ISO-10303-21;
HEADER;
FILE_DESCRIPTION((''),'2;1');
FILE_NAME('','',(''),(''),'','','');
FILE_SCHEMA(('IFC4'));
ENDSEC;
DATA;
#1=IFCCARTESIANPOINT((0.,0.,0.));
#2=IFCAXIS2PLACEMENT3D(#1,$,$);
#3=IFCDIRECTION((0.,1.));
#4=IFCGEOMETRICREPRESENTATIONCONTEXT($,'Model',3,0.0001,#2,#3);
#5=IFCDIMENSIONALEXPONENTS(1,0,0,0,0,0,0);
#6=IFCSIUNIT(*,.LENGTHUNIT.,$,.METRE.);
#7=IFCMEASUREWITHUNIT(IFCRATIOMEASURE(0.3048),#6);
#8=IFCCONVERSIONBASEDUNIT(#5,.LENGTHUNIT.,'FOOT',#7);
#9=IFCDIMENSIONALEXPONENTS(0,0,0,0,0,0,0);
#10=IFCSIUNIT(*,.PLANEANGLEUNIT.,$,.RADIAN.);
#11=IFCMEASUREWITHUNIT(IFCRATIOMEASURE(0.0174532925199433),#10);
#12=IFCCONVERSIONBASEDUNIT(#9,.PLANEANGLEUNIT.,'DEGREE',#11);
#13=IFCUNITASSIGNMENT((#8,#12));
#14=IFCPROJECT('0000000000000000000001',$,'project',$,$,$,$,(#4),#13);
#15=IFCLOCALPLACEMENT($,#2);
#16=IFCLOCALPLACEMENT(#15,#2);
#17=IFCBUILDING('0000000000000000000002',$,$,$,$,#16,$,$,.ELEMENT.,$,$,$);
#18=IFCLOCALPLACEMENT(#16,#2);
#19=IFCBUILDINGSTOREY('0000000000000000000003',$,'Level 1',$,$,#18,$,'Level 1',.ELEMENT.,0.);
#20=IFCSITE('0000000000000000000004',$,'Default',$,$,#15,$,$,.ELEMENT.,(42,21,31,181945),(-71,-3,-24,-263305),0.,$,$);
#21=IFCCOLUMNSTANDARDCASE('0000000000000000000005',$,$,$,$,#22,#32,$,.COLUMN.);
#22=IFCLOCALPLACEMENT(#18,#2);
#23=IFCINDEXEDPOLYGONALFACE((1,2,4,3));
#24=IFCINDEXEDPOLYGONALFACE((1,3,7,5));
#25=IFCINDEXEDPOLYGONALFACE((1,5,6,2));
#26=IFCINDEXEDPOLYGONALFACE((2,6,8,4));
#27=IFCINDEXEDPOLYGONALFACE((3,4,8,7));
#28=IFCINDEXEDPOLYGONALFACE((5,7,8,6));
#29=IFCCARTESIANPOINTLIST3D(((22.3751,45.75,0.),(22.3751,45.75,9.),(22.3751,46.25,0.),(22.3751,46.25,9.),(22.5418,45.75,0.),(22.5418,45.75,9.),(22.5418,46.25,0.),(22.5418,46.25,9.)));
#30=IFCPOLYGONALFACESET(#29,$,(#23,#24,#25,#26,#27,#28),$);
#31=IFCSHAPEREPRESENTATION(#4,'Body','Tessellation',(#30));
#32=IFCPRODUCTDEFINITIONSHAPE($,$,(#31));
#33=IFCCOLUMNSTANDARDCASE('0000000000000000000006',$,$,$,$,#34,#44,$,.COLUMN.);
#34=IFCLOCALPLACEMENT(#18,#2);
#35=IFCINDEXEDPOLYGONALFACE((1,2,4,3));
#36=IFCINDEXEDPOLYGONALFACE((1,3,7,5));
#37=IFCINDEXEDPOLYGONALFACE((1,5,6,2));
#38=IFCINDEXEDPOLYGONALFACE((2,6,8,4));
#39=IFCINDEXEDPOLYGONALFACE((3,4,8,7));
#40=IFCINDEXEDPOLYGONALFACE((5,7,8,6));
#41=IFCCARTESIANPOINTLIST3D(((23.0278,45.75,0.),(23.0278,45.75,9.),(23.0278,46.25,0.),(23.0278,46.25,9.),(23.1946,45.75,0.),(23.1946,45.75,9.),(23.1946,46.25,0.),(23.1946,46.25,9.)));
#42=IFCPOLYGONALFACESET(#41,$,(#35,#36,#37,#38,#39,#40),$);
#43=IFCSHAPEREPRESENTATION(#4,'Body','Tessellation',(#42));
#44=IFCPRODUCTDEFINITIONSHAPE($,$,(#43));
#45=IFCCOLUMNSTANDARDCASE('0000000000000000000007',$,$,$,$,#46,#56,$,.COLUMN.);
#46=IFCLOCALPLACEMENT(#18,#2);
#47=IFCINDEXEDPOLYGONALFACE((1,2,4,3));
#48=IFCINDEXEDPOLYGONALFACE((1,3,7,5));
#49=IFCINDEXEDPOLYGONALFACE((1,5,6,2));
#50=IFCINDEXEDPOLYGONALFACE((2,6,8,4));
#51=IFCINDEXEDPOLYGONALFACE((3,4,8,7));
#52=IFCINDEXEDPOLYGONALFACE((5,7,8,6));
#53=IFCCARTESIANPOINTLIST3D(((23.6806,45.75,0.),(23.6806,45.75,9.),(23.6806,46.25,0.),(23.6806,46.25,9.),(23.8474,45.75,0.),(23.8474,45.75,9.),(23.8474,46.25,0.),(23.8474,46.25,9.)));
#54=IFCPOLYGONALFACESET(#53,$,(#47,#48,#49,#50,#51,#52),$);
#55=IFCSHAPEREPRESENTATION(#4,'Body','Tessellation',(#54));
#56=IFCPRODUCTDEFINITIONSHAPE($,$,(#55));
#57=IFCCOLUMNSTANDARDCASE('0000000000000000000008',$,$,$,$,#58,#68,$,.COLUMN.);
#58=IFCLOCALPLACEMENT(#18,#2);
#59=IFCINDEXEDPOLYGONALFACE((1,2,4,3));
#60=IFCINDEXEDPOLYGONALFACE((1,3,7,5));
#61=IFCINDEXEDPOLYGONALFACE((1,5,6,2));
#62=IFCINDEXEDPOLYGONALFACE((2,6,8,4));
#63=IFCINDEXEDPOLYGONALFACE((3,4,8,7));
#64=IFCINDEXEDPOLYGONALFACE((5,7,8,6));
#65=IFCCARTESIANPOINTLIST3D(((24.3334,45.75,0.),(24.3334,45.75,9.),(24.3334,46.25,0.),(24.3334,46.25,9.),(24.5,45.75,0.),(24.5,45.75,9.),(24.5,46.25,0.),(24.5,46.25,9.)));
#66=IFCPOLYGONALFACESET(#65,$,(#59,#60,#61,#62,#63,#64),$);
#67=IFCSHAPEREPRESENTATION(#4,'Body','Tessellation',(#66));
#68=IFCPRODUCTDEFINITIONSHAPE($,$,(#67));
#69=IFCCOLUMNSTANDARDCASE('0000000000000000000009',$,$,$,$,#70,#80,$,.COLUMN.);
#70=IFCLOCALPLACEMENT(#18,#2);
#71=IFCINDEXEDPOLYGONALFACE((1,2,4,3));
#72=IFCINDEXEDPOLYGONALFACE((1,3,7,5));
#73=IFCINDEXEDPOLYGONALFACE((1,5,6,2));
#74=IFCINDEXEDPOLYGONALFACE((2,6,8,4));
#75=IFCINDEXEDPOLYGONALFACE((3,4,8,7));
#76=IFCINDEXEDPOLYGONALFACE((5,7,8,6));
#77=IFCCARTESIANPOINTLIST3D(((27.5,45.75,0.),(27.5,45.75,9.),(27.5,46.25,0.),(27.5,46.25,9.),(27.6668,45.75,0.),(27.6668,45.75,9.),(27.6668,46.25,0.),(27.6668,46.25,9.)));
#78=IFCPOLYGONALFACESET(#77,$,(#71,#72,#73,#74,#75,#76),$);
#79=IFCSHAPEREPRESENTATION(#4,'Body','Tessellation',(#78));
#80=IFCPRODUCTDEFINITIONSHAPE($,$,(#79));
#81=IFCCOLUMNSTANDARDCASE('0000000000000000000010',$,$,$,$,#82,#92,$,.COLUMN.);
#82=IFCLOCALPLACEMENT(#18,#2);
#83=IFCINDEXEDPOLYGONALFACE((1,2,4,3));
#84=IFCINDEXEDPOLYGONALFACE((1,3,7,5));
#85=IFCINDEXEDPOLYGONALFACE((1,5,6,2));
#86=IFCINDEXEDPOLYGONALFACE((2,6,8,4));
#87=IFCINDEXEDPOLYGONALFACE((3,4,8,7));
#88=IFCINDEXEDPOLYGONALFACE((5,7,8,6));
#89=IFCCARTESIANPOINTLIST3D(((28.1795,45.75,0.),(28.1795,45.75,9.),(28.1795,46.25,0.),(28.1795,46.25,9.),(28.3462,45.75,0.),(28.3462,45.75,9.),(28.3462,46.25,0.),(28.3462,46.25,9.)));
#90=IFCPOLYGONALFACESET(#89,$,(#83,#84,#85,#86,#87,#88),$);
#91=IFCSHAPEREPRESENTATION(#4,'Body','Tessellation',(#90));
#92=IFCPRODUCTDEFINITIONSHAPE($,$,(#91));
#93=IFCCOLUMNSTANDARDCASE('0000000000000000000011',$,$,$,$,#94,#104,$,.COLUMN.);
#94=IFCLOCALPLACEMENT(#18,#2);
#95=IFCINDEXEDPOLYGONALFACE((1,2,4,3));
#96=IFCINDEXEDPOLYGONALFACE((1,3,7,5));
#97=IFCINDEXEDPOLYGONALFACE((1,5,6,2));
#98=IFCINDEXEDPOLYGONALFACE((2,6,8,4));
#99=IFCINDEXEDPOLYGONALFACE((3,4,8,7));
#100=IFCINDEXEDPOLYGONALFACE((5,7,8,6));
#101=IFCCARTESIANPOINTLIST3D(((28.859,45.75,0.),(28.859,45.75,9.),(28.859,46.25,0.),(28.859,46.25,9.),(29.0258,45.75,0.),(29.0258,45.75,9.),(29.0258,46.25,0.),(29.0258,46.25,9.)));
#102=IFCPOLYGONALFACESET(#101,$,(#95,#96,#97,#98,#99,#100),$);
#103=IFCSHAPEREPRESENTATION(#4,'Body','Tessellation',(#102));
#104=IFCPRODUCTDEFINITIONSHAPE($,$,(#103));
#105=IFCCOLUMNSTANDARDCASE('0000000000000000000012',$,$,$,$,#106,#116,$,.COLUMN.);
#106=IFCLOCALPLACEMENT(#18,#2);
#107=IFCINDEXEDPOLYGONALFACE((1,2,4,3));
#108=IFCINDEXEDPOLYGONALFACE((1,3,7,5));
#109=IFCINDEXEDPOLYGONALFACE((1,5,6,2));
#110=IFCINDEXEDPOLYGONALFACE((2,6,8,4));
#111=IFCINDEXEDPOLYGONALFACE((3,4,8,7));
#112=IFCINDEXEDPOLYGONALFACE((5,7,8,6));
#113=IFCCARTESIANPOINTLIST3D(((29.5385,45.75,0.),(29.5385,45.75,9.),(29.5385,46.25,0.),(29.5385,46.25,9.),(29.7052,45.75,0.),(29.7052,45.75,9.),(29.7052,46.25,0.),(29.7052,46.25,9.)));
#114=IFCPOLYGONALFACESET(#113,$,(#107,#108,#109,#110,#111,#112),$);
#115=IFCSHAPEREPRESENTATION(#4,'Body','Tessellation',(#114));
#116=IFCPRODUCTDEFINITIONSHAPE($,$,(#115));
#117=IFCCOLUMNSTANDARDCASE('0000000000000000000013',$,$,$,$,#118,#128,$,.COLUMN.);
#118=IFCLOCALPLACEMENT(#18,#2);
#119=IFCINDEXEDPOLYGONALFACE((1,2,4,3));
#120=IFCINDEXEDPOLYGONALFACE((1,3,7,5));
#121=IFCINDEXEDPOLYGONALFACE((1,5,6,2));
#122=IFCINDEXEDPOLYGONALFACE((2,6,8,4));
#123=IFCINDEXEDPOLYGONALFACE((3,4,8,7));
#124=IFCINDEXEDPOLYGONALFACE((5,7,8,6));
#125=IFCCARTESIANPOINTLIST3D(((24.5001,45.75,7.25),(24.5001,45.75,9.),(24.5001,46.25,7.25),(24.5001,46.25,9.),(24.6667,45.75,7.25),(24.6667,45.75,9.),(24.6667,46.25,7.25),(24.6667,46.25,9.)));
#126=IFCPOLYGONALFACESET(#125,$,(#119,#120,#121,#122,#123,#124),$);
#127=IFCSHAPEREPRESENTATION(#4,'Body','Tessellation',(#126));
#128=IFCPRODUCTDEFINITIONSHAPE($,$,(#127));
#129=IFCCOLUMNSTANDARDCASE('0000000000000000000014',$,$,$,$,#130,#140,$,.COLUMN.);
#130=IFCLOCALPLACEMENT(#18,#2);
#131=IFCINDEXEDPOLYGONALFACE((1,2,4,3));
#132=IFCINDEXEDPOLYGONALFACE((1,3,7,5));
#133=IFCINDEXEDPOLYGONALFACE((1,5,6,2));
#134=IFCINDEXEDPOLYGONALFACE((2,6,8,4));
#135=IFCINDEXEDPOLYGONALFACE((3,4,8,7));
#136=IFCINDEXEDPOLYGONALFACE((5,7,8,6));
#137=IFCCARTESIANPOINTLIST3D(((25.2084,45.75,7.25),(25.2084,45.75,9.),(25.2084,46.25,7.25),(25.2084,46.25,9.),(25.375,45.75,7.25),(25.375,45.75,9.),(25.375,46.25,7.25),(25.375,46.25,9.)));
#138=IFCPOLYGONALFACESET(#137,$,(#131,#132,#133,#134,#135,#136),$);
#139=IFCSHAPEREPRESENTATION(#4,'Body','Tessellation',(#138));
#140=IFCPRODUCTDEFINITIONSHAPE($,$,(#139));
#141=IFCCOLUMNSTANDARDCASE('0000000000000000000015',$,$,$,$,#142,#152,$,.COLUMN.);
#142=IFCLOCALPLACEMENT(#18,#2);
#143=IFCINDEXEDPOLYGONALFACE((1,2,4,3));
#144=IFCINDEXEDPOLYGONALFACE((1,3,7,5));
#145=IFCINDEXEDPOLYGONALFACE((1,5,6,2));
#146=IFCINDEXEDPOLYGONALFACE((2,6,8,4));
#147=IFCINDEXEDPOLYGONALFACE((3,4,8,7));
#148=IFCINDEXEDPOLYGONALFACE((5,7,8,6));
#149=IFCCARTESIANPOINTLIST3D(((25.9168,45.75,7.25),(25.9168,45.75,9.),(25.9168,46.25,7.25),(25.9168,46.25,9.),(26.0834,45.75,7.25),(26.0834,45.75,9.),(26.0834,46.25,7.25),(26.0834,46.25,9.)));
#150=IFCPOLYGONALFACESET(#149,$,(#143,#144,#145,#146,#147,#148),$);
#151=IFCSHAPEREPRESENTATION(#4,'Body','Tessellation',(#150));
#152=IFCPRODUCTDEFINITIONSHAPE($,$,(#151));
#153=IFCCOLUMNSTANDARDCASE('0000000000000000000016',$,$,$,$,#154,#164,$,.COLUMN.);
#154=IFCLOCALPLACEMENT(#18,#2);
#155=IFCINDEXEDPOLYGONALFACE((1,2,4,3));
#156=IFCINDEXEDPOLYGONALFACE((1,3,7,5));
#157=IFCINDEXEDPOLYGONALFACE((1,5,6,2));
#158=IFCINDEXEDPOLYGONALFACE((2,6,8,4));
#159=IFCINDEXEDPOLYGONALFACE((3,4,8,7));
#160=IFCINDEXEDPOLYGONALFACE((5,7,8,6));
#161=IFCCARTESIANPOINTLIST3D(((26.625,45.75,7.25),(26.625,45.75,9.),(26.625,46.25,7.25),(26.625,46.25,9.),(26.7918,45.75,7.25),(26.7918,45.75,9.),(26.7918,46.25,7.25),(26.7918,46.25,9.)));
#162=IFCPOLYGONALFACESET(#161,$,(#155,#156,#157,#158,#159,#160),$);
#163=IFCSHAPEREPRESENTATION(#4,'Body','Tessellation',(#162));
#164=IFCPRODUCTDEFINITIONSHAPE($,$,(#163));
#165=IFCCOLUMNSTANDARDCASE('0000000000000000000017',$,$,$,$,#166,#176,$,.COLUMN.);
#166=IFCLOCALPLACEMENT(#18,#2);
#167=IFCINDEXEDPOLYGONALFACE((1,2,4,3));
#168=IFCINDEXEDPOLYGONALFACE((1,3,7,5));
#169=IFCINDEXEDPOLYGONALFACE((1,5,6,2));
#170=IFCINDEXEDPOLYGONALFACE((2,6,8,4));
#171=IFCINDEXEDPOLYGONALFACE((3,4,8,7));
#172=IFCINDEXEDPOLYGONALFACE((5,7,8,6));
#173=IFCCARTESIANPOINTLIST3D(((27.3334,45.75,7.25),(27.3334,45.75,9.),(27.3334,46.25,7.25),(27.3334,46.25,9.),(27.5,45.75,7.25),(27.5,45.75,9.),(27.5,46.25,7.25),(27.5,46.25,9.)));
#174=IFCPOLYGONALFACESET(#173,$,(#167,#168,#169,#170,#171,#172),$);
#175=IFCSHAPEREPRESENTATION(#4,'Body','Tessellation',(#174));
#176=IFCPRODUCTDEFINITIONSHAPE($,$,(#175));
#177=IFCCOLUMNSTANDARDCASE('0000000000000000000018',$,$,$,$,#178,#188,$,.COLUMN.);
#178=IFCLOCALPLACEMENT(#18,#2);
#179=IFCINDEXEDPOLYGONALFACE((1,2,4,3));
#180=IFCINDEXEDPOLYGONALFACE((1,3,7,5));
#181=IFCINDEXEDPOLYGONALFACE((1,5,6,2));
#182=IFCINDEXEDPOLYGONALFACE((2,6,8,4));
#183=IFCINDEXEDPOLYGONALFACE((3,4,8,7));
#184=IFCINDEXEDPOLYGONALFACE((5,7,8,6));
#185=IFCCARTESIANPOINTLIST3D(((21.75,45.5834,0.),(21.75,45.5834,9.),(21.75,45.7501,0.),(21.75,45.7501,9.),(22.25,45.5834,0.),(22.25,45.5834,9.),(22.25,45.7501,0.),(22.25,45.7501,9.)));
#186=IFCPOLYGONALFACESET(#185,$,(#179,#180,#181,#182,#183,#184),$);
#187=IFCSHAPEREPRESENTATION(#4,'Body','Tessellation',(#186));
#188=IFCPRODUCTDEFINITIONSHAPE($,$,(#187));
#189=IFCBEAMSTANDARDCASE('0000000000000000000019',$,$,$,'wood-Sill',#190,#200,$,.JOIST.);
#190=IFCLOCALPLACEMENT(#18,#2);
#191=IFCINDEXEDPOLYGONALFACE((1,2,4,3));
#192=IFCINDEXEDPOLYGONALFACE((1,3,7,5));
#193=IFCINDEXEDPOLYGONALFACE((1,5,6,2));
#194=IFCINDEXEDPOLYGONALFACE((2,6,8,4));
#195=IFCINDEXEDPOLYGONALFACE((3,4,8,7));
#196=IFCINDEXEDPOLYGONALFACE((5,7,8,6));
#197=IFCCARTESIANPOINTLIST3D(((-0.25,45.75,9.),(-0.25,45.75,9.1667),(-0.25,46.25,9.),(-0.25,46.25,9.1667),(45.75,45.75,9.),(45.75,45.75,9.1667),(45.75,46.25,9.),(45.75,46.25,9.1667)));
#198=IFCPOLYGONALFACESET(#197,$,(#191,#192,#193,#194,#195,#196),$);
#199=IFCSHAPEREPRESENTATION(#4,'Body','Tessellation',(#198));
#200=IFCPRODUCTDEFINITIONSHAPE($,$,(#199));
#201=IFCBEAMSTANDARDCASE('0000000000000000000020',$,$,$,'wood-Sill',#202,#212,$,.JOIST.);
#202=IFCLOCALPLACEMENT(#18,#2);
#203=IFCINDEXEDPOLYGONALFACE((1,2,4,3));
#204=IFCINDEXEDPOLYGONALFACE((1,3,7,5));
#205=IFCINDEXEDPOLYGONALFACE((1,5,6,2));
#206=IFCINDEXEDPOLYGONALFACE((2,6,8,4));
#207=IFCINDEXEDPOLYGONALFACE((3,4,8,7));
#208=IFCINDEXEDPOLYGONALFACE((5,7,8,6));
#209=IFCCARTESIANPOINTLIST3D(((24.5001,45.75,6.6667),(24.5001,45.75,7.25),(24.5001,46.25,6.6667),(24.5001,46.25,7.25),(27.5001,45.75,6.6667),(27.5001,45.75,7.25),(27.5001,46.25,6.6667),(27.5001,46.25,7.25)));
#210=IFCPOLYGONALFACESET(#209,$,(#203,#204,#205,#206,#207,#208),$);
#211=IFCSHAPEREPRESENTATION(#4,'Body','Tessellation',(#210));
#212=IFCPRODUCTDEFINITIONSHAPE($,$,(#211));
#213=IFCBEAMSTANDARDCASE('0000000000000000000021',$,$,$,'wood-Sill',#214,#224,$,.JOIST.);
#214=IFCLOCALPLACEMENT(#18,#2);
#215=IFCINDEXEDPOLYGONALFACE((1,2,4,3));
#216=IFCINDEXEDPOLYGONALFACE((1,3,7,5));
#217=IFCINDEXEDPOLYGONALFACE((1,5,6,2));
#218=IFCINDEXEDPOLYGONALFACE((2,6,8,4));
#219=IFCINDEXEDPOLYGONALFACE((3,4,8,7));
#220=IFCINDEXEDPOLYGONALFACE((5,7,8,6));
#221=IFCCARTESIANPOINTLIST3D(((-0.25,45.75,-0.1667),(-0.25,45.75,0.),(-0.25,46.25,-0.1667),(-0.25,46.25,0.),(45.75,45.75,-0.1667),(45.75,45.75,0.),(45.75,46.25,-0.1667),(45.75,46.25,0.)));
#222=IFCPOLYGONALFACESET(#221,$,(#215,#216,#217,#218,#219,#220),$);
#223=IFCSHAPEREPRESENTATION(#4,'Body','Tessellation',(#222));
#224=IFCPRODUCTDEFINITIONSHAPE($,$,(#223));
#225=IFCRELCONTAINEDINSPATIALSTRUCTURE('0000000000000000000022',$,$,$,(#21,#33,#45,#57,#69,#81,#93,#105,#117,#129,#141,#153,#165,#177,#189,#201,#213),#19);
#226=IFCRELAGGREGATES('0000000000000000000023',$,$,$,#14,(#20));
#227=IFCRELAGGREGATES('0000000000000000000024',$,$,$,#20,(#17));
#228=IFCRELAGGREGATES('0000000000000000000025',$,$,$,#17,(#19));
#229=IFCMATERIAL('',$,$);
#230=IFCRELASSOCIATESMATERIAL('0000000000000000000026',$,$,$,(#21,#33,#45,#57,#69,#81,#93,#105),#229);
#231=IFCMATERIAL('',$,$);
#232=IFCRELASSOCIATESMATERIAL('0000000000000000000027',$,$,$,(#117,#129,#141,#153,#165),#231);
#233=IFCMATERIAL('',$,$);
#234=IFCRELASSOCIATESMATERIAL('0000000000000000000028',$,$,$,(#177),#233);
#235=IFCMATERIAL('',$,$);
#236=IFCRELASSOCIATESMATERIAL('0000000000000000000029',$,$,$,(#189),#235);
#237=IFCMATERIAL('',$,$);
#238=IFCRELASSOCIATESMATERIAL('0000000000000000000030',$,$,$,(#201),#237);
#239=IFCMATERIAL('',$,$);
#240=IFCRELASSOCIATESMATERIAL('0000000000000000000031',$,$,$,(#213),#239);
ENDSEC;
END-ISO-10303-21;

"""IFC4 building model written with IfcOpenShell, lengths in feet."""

from ifc_helpers import new_model, entity, si_unit, converted_unit, direction, frame, origin, place, context, project, spatial, rectangle, extrude, material, element, save


model = new_model("IFC4")

# Units and contexts
model_context = context("Model", 3, precision=0.0001, world=origin(), true_north=direction((0.0, 1.0)))
ifc_project = project(units=[converted_unit("LENGTHUNIT", "FOOT", entity("IfcRatioMeasure", 0.3048), si_unit("LENGTHUNIT", "METRE"), dimensions=[1, 0, 0, 0, 0, 0, 0]), converted_unit("PLANEANGLEUNIT", "DEGREE", entity("IfcRatioMeasure", 0.0174532925199433), si_unit("PLANEANGLEUNIT", "RADIAN"), dimensions=[0, 0, 0, 0, 0, 0, 0])], contexts=[model_context])

# Site, building, storey
site_placement = place(None, origin())
site = spatial("IfcSite", under=ifc_project, at=site_placement, Name="Default", CompositionType="ELEMENT", RefLatitude=(42, 21, 31, 181945), RefLongitude=(-71, -3, -24, -263305), RefElevation=0.0)
building_placement = place(site_placement, origin())
building = spatial("IfcBuilding", under=site, at=building_placement, CompositionType="ELEMENT")
storey_placement = place(building_placement, origin())
storey = spatial("IfcBuildingStorey", under=building, at=storey_placement, Name="Level 1", LongName="Level 1", CompositionType="ELEMENT", Elevation=0.0)

# Columns
ifc_material_1 = material(Name="")
placement_1 = place(storey_placement, frame((-0.25, 46.0, 0.0)))
for number, where, z_axis, x_axis in (
    (1, (22.7084, 0.0, 0.0), (0.0, 0.0, 1.0), (1.0, 0.0, 0.0)),
    (2, (23.3612, 0.0, 0.0), (0.0, 0.0, 1.0), (1.0, 0.0, 0.0)),
    (3, (24.014, 0.0, 0.0), (0.0, 0.0, 1.0), (1.0, 0.0, 0.0)),
    (4, (24.6667, 0.0, 0.0), (0.0, 0.0, 1.0), (1.0, 0.0, 0.0)),
    (5, (27.8334, 0.0, 0.0), (0.0, 0.0, 1.0), (1.0, 0.0, 0.0)),
    (6, (28.5129, 0.0, 0.0), (0.0, 0.0, 1.0), (1.0, 0.0, 0.0)),
    (7, (29.1924, 0.0, 0.0), (0.0, 0.0, 1.0), (1.0, 0.0, 0.0)),
    (8, (29.8719, 0.0, 0.0), (0.0, 0.0, 1.0), (1.0, 0.0, 0.0)),
):
    element("IfcColumnStandardCase", number, at=place(placement_1, frame(where, z_axis=z_axis, x_axis=x_axis)), inside=storey, material=ifc_material_1, PredefinedType="COLUMN", context=model_context, shape_type="SweptSolid", body=[
        extrude(rectangle(XDim=0.1667, YDim=0.5), origin(), (0.0, 0.0, 1.0), 9.0),
    ])
ifc_material_2 = material(Name="")
for number, where, z_axis, x_axis in (
    (9, (24.8334, 0.0, 7.25), (0.0, 0.0, 1.0), (1.0, 0.0, 0.0)),
    (10, (25.5417, 0.0, 7.25), (0.0, 0.0, 1.0), (1.0, 0.0, 0.0)),
    (11, (26.2501, 0.0, 7.25), (0.0, 0.0, 1.0), (1.0, 0.0, 0.0)),
    (12, (26.9584, 0.0, 7.25), (0.0, 0.0, 1.0), (1.0, 0.0, 0.0)),
    (13, (27.6667, 0.0, 7.25), (0.0, 0.0, 1.0), (1.0, 0.0, 0.0)),
):
    element("IfcColumnStandardCase", number, at=place(placement_1, frame(where, z_axis=z_axis, x_axis=x_axis)), inside=storey, material=ifc_material_2, PredefinedType="COLUMN", context=model_context, shape_type="SweptSolid", body=[
        extrude(rectangle(XDim=0.1667, YDim=0.5), origin(), (0.0, 0.0, 1.0), 1.75),
    ])
ifc_material_3 = material(Name="")
placement_2 = place(storey_placement, frame((22.0, 45.75, 0.0), z_axis=(0.0, 0.0, 1.0), x_axis=(0.0, -1.0, 0.0)))
for number, where, z_axis, x_axis in (
    (14, (0.0833, 0.0, 0.0), (0.0, 0.0, 1.0), (1.0, 0.0, 0.0)),
):
    element("IfcColumnStandardCase", number, at=place(placement_2, frame(where, z_axis=z_axis, x_axis=x_axis)), inside=storey, material=ifc_material_3, PredefinedType="COLUMN", context=model_context, shape_type="SweptSolid", body=[
        extrude(rectangle(XDim=0.1667, YDim=0.5), origin(), (0.0, 0.0, 1.0), 9.0),
    ])

# Beams
ifc_material_4 = material(Name="")
beam_1_placement = place(placement_1, frame((23.0, 0.0, 9.0), z_axis=(0.0, 0.0, 1.0), x_axis=(1.0, 0.0, 0.0)))
element("IfcBeamStandardCase", 15, at=beam_1_placement, inside=storey, material=ifc_material_4, ObjectType="wood-Sill", PredefinedType="JOIST", context=model_context, shape_type="SweptSolid", body=[
    extrude(rectangle(XDim=46.0, YDim=0.5), origin(), (0.0, 0.0, 1.0), 0.1667),
])
ifc_material_5 = material(Name="")
for number, where, z_axis, x_axis in (
    (16, (26.2501, 0.0, 6.6667), (0.0, 0.0, 1.0), (-1.0, 0.0, 0.0)),
):
    element("IfcBeamStandardCase", number, at=place(placement_1, frame(where, z_axis=z_axis, x_axis=x_axis)), inside=storey, material=ifc_material_5, ObjectType="wood-Sill", PredefinedType="JOIST", context=model_context, shape_type="SweptSolid", body=[
        extrude(rectangle(XDim=3.0, YDim=0.5), origin(), (0.0, 0.0, 1.0), 0.5833),
    ])
ifc_material_6 = material(Name="")
beam_2_placement = place(placement_1, frame((23.0, 0.0, -0.1667), z_axis=(0.0, 0.0, 1.0), x_axis=(1.0, 0.0, 0.0)))
element("IfcBeamStandardCase", 17, at=beam_2_placement, inside=storey, material=ifc_material_6, ObjectType="wood-Sill", PredefinedType="JOIST", context=model_context, shape_type="SweptSolid", body=[
    extrude(rectangle(XDim=46.0, YDim=0.5), origin(), (0.0, 0.0, 1.0), 0.1667),
])

save(model, "model.ifc")
